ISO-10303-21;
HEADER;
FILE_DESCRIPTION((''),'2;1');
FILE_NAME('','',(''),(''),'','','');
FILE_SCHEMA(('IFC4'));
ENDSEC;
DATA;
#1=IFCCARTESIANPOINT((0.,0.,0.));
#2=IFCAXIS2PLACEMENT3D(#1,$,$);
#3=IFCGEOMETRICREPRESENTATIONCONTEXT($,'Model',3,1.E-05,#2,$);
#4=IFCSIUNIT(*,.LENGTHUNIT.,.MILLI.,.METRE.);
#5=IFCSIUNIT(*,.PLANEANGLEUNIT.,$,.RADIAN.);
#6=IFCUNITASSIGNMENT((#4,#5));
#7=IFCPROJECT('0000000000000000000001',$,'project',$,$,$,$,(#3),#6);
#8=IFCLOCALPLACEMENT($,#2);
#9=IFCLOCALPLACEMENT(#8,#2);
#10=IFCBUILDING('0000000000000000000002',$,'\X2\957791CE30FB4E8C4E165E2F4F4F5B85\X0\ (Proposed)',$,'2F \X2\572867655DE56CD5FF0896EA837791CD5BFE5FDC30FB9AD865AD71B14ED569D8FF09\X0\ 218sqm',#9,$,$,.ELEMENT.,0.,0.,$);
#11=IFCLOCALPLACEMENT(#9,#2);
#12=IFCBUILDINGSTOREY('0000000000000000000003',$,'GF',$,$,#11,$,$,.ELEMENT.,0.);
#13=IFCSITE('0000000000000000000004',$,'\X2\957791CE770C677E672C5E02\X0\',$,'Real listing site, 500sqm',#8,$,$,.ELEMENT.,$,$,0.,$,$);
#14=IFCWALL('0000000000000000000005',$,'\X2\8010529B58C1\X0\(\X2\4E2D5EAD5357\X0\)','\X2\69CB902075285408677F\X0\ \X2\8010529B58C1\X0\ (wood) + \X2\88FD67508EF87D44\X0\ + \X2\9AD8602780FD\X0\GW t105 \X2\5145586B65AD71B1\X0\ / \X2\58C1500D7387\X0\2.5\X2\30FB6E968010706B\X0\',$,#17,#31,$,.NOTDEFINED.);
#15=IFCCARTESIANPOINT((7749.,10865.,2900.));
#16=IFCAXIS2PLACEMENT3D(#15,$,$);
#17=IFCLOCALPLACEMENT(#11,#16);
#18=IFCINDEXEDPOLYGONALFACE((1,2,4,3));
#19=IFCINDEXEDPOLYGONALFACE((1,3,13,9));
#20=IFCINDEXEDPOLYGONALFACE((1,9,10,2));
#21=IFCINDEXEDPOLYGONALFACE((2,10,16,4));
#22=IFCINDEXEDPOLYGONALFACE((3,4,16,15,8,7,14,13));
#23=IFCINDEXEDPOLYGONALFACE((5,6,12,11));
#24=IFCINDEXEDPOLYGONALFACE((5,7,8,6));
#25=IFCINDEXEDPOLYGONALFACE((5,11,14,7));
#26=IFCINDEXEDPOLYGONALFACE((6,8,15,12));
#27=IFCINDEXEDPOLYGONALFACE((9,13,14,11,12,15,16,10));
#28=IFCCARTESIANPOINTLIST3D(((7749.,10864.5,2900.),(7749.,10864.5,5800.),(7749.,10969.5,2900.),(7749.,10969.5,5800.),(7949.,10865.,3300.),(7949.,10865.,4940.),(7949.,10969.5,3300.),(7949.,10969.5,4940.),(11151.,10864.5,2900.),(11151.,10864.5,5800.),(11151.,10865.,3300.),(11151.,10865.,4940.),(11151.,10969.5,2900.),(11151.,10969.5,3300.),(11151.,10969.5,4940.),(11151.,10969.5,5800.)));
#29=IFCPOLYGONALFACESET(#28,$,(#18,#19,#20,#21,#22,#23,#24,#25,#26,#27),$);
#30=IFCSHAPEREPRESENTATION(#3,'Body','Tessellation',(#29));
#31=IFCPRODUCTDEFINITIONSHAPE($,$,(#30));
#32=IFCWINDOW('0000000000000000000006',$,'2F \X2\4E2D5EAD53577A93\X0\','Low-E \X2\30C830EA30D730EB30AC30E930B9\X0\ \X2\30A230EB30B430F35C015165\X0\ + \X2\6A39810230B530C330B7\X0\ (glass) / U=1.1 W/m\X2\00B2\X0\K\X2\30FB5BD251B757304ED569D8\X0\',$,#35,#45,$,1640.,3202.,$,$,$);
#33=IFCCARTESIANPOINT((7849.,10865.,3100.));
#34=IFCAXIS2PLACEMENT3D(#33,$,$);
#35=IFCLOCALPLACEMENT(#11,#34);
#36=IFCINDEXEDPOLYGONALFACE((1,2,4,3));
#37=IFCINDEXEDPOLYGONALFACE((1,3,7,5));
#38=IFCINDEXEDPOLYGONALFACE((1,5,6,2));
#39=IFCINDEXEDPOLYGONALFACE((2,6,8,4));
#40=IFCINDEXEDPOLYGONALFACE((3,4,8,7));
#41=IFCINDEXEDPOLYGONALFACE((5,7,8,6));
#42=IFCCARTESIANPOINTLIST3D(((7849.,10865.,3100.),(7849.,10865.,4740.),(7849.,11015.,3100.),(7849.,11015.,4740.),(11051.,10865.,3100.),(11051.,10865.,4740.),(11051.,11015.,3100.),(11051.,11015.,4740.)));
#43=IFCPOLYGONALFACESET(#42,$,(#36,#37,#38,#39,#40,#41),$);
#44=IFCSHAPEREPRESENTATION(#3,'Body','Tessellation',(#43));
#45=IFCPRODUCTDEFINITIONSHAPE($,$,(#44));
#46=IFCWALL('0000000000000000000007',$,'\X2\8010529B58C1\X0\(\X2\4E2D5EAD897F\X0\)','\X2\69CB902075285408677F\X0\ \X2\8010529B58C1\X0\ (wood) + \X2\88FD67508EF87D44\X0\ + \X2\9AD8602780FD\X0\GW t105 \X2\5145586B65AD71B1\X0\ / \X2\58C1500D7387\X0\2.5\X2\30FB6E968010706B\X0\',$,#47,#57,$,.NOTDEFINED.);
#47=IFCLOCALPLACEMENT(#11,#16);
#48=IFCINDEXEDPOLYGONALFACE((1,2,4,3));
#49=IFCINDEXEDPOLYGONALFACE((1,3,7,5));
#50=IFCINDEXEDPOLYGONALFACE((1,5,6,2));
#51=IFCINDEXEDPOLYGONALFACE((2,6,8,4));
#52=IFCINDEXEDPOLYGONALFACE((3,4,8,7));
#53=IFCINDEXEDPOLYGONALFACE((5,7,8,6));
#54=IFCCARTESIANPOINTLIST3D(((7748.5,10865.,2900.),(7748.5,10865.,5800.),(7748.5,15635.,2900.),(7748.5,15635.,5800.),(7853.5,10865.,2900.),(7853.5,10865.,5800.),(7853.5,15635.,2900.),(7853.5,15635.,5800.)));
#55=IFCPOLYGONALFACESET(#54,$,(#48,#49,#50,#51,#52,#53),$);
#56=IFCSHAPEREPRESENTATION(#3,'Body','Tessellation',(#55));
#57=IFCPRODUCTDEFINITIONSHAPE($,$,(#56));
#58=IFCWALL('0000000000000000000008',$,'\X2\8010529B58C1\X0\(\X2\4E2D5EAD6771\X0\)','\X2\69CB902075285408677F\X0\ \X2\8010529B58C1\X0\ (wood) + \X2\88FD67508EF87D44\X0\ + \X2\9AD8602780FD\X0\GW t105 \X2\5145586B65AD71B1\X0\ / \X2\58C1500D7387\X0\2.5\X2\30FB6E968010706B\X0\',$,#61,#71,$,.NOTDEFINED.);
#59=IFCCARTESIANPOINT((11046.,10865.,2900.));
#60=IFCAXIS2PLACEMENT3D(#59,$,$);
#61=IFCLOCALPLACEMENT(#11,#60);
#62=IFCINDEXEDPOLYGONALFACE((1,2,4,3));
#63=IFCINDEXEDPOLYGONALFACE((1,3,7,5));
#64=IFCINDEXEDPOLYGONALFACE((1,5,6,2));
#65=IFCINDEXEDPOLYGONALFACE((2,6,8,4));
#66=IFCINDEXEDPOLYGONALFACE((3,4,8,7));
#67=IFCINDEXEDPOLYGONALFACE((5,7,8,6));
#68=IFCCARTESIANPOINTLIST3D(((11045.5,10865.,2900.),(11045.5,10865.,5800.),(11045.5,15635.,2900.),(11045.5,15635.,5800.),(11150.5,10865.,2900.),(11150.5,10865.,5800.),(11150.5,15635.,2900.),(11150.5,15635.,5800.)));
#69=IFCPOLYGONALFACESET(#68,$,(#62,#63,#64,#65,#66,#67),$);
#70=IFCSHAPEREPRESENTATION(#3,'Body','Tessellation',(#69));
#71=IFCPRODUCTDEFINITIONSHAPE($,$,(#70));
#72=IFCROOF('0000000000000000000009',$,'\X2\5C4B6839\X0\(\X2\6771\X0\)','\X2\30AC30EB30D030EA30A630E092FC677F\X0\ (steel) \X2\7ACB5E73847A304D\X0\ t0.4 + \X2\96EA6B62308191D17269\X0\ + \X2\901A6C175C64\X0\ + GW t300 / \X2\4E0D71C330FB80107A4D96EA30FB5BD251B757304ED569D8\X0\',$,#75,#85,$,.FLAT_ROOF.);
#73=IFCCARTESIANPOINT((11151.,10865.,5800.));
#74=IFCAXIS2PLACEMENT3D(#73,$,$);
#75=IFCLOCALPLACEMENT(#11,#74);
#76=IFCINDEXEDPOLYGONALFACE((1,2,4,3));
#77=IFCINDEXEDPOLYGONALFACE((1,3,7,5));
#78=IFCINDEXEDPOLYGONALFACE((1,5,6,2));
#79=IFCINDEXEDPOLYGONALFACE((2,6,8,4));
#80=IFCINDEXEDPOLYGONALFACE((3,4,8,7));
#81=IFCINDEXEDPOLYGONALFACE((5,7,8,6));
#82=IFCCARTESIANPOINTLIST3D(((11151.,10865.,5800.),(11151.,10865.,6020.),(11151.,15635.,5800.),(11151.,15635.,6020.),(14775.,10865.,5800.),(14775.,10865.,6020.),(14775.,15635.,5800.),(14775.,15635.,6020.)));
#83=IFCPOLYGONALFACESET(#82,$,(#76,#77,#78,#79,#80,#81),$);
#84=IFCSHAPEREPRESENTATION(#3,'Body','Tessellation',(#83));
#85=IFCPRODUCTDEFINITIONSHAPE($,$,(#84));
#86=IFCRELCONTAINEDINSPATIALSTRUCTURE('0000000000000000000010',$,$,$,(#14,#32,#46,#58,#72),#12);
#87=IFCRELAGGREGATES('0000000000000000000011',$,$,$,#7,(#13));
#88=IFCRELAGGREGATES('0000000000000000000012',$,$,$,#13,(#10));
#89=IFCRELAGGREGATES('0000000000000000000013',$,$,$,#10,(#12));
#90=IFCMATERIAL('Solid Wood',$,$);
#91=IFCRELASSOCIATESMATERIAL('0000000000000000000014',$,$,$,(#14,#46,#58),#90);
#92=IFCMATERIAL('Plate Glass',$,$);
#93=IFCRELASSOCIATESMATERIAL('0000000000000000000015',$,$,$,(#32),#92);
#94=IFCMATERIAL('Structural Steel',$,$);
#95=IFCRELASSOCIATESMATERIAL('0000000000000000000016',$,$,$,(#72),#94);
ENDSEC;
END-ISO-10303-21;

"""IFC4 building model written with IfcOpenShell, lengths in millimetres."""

from ifc_helpers import new_model, si_unit, frame, frame_2d, origin, place, context, project, spatial, rectangle, extrude, material, element, fill, save


model = new_model("IFC4")

# Units and contexts
model_context = context("Model", 3, precision=1e-05, world=origin())
ifc_project = project(units=[si_unit("LENGTHUNIT", "METRE", prefix="MILLI"), si_unit("PLANEANGLEUNIT", "RADIAN")], contexts=[model_context])

# Site, building, storey
site_placement = place(None, origin())
site = spatial("IfcSite", under=ifc_project, at=site_placement, Name="長野県松本市", ObjectType="Real listing site, 500sqm", CompositionType="ELEMENT", RefElevation=0.0)
building_placement = place(site_placement, origin())
building = spatial("IfcBuilding", under=site, at=building_placement, Name="長野・二世帯住宅 (Proposed)", ObjectType="2F 在来工法（雪荷重対応・高断熱仕様） 218sqm", CompositionType="ELEMENT", ElevationOfRefHeight=0.0, ElevationOfTerrain=0.0)
storey_placement = place(building_placement, origin())
storey = spatial("IfcBuildingStorey", under=building, at=storey_placement, Name="GF", CompositionType="ELEMENT", Elevation=0.0)

# Shared definitions
ifc_material_1 = material(Name="Solid Wood")

# Shared definitions
ifc_material_2 = material(Name="Plate Glass")

# Wall, opening, window
wall_1_placement = place(storey_placement, frame((7749.0, 10865.0, 2900.0)))
wall_1 = element("IfcWall", 1, at=wall_1_placement, inside=storey, material=ifc_material_1, Name="耐力壁(中庭南)", Description="構造用合板 耐力壁 (wood) + 製材軸組 + 高性能GW t105 充填断熱 / 壁倍率2.5・準耐火", PredefinedType="NOTDEFINED", context=model_context, shape_type="SweptSolid", body=[
    extrude(rectangle(XDim=3402.0, YDim=105.0, at=frame_2d((1701.0, 52.0))), frame((7749.0, 10865.0, 2900.0)), (0.0, 0.0, 1.0), 2900.0),
])
opening_1_placement = place(storey_placement, frame((7849.0, 10865.0, 3100.0)))
opening_1 = element("IfcOpeningElement", 2, at=opening_1_placement, cuts=wall_1, PredefinedType="NOTDEFINED", context=model_context, shape_type="SweptSolid", body=[
    extrude(rectangle(XDim=3202.0, YDim=150.0, at=frame_2d((1601.0, 75.0))), frame((7849.0, 10865.0, 3100.0)), (0.0, 0.0, 1.0), 1640.0),
])
window_1_placement = place(storey_placement, frame((7849.0, 10865.0, 3100.0)))
window_1 = element("IfcWindow", 3, at=window_1_placement, inside=storey, material=ifc_material_2, Name="2F 中庭南窓", Description="Low-E トリプルガラス アルゴン封入 + 樹脂サッシ (glass) / U=1.1 W/m²K・寒冷地仕様", OverallHeight=1640.0, OverallWidth=3202.0, context=model_context, shape_type="SweptSolid", body=[
    extrude(rectangle(XDim=3202.0, YDim=150.0, at=frame_2d((1601.0, 75.0))), frame((7849.0, 10865.0, 3100.0)), (0.0, 0.0, 1.0), 1640.0),
])
fill(opening_1, window_1)

# Walls
wall_2_placement = place(storey_placement, frame((7749.0, 10865.0, 2900.0)))
element("IfcWall", 4, at=wall_2_placement, inside=storey, material=ifc_material_1, Name="耐力壁(中庭西)", Description="構造用合板 耐力壁 (wood) + 製材軸組 + 高性能GW t105 充填断熱 / 壁倍率2.5・準耐火", PredefinedType="NOTDEFINED", context=model_context, shape_type="SweptSolid", body=[
    extrude(rectangle(XDim=105.0, YDim=4770.0, at=frame_2d((52.0, 2385.0))), frame((7749.0, 10865.0, 2900.0)), (0.0, 0.0, 1.0), 2900.0),
])
wall_3_placement = place(storey_placement, frame((11046.0, 10865.0, 2900.0)))
element("IfcWall", 5, at=wall_3_placement, inside=storey, material=ifc_material_1, Name="耐力壁(中庭東)", Description="構造用合板 耐力壁 (wood) + 製材軸組 + 高性能GW t105 充填断熱 / 壁倍率2.5・準耐火", PredefinedType="NOTDEFINED", context=model_context, shape_type="SweptSolid", body=[
    extrude(rectangle(XDim=105.0, YDim=4770.0, at=frame_2d((52.0, 2385.0))), frame((11046.0, 10865.0, 2900.0)), (0.0, 0.0, 1.0), 2900.0),
])

# Roof
ifc_material_3 = material(Name="Structural Steel")
for number, where, name in (
    (6, (11151.0, 10865.0, 5800.0), "屋根(東)"),
):
    element("IfcRoof", number, at=place(storey_placement, frame(where)), inside=storey, material=ifc_material_3, Name=name, Description="ガルバリウム鋼板 (steel) 立平葺き t0.4 + 雪止め金物 + 通気層 + GW t300 / 不燃・耐積雪・寒冷地仕様", PredefinedType="FLAT_ROOF", context=model_context, shape_type="SweptSolid", body=[
        extrude(rectangle(XDim=3624.0, YDim=4770.0, at=frame_2d((1812.0, 2385.0))), frame((11151.0, 10865.0, 5800.0)), (0.0, 0.0, 1.0), 220.0),
    ])

save(model, "model.ifc")
